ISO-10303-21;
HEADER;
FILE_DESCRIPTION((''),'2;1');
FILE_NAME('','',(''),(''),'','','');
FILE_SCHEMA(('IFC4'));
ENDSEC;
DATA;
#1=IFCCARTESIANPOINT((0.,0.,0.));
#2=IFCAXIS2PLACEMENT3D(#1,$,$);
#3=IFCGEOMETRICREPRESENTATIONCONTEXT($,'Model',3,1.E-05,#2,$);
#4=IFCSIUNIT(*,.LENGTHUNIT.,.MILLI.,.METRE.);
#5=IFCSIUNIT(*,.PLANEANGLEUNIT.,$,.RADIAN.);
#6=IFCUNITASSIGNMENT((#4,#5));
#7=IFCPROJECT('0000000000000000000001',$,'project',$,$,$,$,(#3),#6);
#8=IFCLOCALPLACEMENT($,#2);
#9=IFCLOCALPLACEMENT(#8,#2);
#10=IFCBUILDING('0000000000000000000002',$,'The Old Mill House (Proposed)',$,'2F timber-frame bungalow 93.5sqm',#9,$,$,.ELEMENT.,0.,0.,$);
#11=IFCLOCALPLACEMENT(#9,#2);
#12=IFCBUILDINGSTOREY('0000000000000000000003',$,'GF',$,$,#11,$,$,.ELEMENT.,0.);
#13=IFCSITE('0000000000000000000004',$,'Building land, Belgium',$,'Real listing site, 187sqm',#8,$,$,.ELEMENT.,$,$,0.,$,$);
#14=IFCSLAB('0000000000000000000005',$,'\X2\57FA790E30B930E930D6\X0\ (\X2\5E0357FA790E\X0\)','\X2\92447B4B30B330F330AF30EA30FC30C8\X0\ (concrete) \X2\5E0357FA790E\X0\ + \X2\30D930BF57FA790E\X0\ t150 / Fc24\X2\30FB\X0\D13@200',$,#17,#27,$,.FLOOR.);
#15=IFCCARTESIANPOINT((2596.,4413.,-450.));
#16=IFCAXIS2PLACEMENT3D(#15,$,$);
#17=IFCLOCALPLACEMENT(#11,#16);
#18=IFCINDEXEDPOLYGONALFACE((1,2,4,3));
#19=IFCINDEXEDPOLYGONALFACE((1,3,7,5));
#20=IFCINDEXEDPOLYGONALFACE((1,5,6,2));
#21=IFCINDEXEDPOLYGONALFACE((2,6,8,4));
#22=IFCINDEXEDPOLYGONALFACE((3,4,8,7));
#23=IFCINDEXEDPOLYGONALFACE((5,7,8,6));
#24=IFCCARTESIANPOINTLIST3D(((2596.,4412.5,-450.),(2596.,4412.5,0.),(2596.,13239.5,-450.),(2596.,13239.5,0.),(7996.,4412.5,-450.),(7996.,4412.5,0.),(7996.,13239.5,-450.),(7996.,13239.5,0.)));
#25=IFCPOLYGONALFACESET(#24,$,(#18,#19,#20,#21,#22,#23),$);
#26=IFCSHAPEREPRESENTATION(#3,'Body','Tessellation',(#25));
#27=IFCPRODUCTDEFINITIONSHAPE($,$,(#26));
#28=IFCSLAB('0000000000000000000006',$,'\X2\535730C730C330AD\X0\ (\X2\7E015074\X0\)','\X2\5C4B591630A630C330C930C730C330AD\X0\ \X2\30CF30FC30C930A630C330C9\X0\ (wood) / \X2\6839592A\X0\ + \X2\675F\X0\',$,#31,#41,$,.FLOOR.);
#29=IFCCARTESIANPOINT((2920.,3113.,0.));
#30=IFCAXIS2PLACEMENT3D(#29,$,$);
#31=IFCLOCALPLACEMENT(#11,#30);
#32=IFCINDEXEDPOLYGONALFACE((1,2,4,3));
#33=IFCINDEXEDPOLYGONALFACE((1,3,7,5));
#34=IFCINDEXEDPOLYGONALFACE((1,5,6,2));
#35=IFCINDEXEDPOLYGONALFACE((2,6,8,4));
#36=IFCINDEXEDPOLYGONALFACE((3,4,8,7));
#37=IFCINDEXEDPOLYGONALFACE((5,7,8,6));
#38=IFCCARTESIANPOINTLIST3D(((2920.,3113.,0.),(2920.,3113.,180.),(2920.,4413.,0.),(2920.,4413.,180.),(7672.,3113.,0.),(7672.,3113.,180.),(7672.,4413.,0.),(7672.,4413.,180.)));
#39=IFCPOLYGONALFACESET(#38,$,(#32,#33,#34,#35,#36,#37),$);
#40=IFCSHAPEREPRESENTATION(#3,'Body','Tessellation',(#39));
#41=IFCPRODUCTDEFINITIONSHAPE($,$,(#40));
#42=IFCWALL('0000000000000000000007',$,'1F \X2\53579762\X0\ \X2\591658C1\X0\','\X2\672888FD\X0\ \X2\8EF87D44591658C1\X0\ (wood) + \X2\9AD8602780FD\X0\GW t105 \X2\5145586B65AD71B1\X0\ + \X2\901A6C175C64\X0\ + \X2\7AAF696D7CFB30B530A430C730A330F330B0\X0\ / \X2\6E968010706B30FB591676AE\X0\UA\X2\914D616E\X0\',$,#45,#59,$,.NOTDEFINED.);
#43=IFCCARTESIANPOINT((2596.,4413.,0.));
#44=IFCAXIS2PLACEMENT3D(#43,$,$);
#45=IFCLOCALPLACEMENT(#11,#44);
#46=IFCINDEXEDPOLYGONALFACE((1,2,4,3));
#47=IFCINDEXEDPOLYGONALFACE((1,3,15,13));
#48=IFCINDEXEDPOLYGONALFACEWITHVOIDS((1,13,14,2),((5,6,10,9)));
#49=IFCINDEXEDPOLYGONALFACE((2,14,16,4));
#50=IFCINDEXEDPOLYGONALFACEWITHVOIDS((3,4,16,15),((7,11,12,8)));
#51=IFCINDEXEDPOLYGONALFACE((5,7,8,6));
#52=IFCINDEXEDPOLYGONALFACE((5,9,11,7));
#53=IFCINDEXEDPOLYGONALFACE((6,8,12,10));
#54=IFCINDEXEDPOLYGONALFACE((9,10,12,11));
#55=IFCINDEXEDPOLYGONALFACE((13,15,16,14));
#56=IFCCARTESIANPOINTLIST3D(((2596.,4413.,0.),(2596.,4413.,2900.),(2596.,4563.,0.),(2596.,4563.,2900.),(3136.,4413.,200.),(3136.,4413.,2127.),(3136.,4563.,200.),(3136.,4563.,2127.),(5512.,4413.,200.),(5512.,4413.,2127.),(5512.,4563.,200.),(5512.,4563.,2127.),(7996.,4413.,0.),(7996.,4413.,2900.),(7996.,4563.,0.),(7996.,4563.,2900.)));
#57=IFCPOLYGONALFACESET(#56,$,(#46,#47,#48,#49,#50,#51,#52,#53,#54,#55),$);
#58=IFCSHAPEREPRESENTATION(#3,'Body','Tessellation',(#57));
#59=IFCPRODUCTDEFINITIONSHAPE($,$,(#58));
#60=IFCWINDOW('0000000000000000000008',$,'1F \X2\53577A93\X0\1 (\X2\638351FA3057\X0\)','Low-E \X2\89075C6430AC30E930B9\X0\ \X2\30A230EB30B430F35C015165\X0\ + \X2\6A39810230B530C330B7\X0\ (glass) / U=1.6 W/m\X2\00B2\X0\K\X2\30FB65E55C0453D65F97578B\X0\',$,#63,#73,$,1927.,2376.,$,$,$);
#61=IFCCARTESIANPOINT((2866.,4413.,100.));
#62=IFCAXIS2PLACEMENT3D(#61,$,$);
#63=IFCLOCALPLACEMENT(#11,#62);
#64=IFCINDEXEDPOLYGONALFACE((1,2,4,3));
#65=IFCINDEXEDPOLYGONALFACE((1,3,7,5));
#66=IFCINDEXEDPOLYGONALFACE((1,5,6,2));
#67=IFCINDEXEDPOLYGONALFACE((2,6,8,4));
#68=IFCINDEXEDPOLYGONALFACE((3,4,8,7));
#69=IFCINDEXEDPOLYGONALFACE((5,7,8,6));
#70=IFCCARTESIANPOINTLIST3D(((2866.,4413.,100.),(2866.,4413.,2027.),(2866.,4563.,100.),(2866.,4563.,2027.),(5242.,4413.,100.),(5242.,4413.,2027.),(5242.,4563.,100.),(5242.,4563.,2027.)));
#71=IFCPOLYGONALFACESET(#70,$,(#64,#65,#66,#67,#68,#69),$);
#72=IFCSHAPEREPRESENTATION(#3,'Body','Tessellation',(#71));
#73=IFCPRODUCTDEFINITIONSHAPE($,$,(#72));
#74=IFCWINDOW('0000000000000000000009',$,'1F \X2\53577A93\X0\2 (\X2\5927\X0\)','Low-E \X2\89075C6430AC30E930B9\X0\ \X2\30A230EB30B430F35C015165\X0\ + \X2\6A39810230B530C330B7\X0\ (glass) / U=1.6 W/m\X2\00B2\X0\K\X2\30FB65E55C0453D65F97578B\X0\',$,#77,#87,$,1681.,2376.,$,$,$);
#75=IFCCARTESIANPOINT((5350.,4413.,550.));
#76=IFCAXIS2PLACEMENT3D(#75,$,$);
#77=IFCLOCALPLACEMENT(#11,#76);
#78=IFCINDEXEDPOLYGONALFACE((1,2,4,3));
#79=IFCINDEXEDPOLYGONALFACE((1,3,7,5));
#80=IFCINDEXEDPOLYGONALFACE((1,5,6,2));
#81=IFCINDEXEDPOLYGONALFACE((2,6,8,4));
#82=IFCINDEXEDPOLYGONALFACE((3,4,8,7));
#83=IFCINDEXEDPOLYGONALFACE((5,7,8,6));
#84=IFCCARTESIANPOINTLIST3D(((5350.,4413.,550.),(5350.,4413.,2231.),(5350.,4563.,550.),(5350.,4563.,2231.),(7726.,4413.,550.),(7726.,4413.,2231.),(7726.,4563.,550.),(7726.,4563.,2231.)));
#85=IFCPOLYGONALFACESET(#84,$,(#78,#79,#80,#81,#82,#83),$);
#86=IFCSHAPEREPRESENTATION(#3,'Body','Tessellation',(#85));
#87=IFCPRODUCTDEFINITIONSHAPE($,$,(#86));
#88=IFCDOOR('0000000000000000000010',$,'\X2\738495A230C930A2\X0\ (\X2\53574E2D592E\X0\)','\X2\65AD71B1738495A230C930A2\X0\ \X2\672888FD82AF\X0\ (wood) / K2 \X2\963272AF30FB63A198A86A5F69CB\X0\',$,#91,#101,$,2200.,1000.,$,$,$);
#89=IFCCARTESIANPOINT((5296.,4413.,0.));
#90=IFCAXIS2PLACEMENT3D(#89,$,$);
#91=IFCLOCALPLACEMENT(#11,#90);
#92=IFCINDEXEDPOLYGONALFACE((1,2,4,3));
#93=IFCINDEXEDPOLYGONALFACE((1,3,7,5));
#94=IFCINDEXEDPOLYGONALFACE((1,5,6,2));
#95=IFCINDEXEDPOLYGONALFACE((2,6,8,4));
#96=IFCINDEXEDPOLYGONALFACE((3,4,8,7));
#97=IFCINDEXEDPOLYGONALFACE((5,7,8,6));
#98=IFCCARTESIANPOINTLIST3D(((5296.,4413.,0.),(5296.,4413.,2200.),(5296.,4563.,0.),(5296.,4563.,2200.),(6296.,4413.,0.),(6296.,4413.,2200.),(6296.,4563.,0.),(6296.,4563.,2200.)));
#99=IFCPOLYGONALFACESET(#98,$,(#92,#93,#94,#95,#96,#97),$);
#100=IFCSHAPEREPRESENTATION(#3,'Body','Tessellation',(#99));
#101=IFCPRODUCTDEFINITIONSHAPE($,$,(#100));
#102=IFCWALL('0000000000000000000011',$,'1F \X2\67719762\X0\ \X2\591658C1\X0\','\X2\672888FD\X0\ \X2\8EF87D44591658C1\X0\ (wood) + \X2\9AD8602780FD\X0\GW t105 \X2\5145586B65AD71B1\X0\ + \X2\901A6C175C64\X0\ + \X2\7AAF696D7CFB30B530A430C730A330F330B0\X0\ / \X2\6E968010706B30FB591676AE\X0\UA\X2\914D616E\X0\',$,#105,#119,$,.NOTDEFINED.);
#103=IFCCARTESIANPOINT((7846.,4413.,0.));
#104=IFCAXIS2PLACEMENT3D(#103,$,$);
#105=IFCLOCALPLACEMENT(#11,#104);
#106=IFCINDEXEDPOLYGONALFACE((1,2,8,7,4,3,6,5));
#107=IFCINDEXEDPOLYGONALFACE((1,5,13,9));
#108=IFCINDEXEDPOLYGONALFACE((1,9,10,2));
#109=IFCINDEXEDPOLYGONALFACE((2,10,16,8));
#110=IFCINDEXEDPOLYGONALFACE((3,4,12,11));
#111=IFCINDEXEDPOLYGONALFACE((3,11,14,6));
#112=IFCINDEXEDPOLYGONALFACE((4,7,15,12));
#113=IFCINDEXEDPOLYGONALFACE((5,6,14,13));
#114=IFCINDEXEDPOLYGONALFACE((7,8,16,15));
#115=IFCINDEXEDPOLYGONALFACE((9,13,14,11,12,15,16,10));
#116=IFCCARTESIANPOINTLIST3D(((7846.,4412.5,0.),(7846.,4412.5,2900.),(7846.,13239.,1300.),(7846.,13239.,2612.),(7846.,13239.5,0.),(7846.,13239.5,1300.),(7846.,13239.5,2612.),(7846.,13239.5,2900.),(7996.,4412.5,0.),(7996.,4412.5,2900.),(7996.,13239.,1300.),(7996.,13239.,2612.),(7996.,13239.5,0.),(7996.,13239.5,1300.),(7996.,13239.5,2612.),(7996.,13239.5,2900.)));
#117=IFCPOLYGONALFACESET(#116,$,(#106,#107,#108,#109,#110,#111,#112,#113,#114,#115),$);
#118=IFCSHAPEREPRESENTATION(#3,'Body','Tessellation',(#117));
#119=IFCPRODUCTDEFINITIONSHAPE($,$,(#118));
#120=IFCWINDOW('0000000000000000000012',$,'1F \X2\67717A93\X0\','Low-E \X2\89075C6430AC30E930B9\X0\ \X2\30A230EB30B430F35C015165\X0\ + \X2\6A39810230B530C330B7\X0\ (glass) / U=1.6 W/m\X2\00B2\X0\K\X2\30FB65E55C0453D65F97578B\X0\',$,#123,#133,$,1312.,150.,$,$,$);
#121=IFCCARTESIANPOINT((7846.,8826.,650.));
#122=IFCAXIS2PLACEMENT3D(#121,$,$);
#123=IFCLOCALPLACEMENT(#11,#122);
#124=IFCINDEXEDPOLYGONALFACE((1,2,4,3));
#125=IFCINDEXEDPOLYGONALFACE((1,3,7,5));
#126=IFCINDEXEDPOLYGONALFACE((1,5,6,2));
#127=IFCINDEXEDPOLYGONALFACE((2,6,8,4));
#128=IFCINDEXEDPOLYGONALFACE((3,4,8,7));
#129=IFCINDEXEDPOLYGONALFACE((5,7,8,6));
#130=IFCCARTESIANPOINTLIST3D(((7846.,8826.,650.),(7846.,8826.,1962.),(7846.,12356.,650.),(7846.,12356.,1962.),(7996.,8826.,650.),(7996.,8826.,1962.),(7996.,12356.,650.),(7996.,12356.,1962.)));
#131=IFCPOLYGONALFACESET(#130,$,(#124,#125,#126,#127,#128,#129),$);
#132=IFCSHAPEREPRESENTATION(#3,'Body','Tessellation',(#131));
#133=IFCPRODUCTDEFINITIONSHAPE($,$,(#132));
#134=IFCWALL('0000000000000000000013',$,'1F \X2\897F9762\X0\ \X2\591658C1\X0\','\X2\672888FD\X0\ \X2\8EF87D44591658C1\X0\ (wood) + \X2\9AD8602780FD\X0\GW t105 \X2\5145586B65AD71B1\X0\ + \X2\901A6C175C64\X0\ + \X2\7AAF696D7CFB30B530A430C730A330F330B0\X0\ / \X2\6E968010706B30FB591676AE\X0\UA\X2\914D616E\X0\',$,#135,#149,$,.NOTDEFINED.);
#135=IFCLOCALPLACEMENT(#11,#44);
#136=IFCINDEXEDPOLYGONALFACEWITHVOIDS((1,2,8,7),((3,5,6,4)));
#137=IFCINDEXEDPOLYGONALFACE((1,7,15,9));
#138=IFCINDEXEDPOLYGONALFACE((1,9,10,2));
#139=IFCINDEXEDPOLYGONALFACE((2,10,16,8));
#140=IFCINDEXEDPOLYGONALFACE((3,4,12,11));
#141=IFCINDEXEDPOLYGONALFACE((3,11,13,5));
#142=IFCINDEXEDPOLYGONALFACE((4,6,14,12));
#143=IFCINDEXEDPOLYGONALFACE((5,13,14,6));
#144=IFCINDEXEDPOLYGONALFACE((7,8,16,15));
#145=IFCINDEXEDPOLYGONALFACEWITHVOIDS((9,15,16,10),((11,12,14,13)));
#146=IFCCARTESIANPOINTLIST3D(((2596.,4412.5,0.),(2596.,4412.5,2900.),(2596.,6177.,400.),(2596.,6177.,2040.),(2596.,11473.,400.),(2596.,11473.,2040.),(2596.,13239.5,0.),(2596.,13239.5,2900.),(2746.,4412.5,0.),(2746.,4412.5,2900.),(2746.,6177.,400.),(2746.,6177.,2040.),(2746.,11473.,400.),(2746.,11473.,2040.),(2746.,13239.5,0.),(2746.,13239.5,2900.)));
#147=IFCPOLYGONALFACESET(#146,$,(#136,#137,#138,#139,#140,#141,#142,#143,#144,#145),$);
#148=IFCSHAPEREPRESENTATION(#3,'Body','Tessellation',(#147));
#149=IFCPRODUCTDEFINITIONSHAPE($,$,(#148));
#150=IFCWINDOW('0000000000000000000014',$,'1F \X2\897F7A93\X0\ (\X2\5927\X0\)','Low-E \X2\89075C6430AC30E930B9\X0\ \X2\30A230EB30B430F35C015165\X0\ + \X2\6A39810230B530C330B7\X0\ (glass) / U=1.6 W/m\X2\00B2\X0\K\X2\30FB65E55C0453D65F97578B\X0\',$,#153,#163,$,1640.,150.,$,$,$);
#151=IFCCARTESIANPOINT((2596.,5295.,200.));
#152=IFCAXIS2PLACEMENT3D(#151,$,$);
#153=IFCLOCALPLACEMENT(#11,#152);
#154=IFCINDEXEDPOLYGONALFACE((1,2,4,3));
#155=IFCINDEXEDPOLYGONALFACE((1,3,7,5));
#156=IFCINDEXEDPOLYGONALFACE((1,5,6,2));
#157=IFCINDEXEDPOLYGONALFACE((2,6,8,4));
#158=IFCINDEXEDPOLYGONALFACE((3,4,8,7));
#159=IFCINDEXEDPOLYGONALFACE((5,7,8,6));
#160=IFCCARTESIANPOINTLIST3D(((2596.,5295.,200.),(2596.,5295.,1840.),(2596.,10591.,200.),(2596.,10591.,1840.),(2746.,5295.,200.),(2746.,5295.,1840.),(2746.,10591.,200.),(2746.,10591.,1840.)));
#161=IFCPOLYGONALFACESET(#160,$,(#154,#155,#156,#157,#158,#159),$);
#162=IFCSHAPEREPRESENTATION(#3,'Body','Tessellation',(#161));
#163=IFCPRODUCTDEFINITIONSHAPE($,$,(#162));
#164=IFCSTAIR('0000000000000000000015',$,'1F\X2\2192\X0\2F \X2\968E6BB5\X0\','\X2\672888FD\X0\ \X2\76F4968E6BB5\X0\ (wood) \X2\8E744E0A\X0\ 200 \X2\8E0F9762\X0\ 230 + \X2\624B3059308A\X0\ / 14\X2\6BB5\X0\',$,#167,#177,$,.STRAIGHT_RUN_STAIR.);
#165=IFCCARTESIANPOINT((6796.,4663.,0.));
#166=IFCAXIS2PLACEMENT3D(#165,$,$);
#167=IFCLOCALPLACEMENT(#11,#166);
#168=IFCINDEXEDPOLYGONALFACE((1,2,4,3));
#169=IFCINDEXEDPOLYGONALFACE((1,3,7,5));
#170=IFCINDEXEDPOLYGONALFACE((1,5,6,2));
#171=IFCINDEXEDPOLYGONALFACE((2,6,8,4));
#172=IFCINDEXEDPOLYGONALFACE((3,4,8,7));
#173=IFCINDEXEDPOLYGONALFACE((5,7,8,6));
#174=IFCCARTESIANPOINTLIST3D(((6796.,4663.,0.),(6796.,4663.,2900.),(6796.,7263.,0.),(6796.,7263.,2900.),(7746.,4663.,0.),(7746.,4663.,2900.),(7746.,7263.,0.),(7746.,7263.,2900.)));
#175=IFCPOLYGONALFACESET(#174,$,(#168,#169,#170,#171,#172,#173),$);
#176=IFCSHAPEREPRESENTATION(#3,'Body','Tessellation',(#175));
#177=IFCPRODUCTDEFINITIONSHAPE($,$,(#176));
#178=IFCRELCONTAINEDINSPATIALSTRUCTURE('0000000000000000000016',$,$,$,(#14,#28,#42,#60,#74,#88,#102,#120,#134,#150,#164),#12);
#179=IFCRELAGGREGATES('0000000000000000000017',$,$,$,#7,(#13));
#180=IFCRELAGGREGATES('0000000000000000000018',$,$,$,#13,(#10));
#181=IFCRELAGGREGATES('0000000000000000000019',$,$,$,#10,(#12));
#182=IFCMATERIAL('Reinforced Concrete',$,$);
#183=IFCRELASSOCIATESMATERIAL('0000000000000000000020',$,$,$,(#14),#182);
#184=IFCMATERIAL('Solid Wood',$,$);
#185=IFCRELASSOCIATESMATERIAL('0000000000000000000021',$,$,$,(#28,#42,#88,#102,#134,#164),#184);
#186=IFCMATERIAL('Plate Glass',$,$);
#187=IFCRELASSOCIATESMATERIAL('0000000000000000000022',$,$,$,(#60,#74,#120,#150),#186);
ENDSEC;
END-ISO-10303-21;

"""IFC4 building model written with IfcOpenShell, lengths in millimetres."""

from ifc_helpers import new_model, si_unit, frame, frame_2d, origin, place, context, project, spatial, rectangle, extrude, material, element, fill, save


model = new_model("IFC4")

# Units and contexts
model_context = context("Model", 3, precision=1e-05, world=origin())
ifc_project = project(units=[si_unit("LENGTHUNIT", "METRE", prefix="MILLI"), si_unit("PLANEANGLEUNIT", "RADIAN")], contexts=[model_context])

# Site, building, storey
site_placement = place(None, origin())
site = spatial("IfcSite", under=ifc_project, at=site_placement, Name="Building land, Belgium", ObjectType="Real listing site, 187sqm", CompositionType="ELEMENT", RefElevation=0.0)
building_placement = place(site_placement, origin())
building = spatial("IfcBuilding", under=site, at=building_placement, Name="The Old Mill House (Proposed)", ObjectType="2F timber-frame bungalow 93.5sqm", CompositionType="ELEMENT", ElevationOfRefHeight=0.0, ElevationOfTerrain=0.0)
storey_placement = place(building_placement, origin())
storey = spatial("IfcBuildingStorey", under=building, at=storey_placement, Name="GF", CompositionType="ELEMENT", Elevation=0.0)

# Slabs
ifc_material_1 = material(Name="Reinforced Concrete")
slab_1_placement = place(storey_placement, frame((2596.0, 4413.0, -450.0)))
element("IfcSlab", 1, at=slab_1_placement, inside=storey, material=ifc_material_1, Name="基礎スラブ (布基礎)", Description="鉄筋コンクリート (concrete) 布基礎 + ベタ基礎 t150 / Fc24・D13@200", PredefinedType="FLOOR", context=model_context, shape_type="SweptSolid", body=[
    extrude(rectangle(XDim=5400.0, YDim=8827.0, at=frame_2d((2700.0, 4413.0))), frame((2596.0, 4413.0, -450.0)), (0.0, 0.0, 1.0), 450.0),
])
ifc_material_2 = material(Name="Solid Wood")
slab_2_placement = place(storey_placement, frame((2920.0, 3113.0, 0.0)))
element("IfcSlab", 2, at=slab_2_placement, inside=storey, material=ifc_material_2, Name="南デッキ (縁側)", Description="屋外ウッドデッキ ハードウッド (wood) / 根太 + 束", PredefinedType="FLOOR", context=model_context, shape_type="SweptSolid", body=[
    extrude(rectangle(XDim=4752.0, YDim=1300.0, at=frame_2d((2376.0, 650.0))), frame((2920.0, 3113.0, 0.0)), (0.0, 0.0, 1.0), 180.0),
])

# Wall, openings, windows, door
wall_1_placement = place(storey_placement, frame((2596.0, 4413.0, 0.0)))
wall_1 = element("IfcWall", 3, at=wall_1_placement, inside=storey, material=ifc_material_2, Name="1F 南面 外壁", Description="木製 軸組外壁 (wood) + 高性能GW t105 充填断熱 + 通気層 + 窯業系サイディング / 準耐火・外皮UA配慮", PredefinedType="NOTDEFINED", context=model_context, shape_type="SweptSolid", body=[
    extrude(rectangle(XDim=5400.0, YDim=150.0, at=frame_2d((2700.0, 75.0))), frame((2596.0, 4413.0, 0.0)), (0.0, 0.0, 1.0), 2900.0),
])
opening_1_placement = place(storey_placement, frame((2866.0, 4413.0, 100.0)))
opening_1 = element("IfcOpeningElement", 4, at=opening_1_placement, cuts=wall_1, PredefinedType="NOTDEFINED", context=model_context, shape_type="SweptSolid", body=[
    extrude(rectangle(XDim=2376.0, YDim=150.0, at=frame_2d((1188.0, 75.0))), frame((2866.0, 4413.0, 100.0)), (0.0, 0.0, 1.0), 1927.0),
])
opening_2_placement = place(storey_placement, frame((5350.0, 4413.0, 550.0)))
opening_2 = element("IfcOpeningElement", 5, at=opening_2_placement, cuts=wall_1, PredefinedType="NOTDEFINED", context=model_context, shape_type="SweptSolid", body=[
    extrude(rectangle(XDim=2376.0, YDim=150.0, at=frame_2d((1188.0, 75.0))), frame((5350.0, 4413.0, 550.0)), (0.0, 0.0, 1.0), 1681.0),
])
opening_3_placement = place(storey_placement, frame((5296.0, 4413.0, 0.0)))
opening_3 = element("IfcOpeningElement", 6, at=opening_3_placement, cuts=wall_1, PredefinedType="NOTDEFINED", context=model_context, shape_type="SweptSolid", body=[
    extrude(rectangle(XDim=1000.0, YDim=150.0, at=frame_2d((500.0, 75.0))), frame((5296.0, 4413.0, 0.0)), (0.0, 0.0, 1.0), 2200.0),
])
ifc_material_3 = material(Name="Plate Glass")
window_1_placement = place(storey_placement, frame((2866.0, 4413.0, 100.0)))
window_1 = element("IfcWindow", 7, at=window_1_placement, inside=storey, material=ifc_material_3, Name="1F 南窓1 (掃出し)", Description="Low-E 複層ガラス アルゴン封入 + 樹脂サッシ (glass) / U=1.6 W/m²K・日射取得型", OverallHeight=1927.0, OverallWidth=2376.0, context=model_context, shape_type="SweptSolid", body=[
    extrude(rectangle(XDim=2376.0, YDim=150.0, at=frame_2d((1188.0, 75.0))), frame((2866.0, 4413.0, 100.0)), (0.0, 0.0, 1.0), 1927.0),
])
fill(opening_1, window_1)
window_2_placement = place(storey_placement, frame((5350.0, 4413.0, 550.0)))
window_2 = element("IfcWindow", 8, at=window_2_placement, inside=storey, material=ifc_material_3, Name="1F 南窓2 (大)", Description="Low-E 複層ガラス アルゴン封入 + 樹脂サッシ (glass) / U=1.6 W/m²K・日射取得型", OverallHeight=1681.0, OverallWidth=2376.0, context=model_context, shape_type="SweptSolid", body=[
    extrude(rectangle(XDim=2376.0, YDim=150.0, at=frame_2d((1188.0, 75.0))), frame((5350.0, 4413.0, 550.0)), (0.0, 0.0, 1.0), 1681.0),
])
fill(opening_2, window_2)
door_placement = place(storey_placement, frame((5296.0, 4413.0, 0.0)))
door = element("IfcDoor", 9, at=door_placement, inside=storey, material=ifc_material_2, Name="玄関ドア (南中央)", Description="断熱玄関ドア 木製芯 (wood) / K2 防犯・採風機構", OverallHeight=2200.0, OverallWidth=1000.0, context=model_context, shape_type="SweptSolid", body=[
    extrude(rectangle(XDim=1000.0, YDim=150.0, at=frame_2d((500.0, 75.0))), frame((5296.0, 4413.0, 0.0)), (0.0, 0.0, 1.0), 2200.0),
])
fill(opening_3, door)

# Walls, openings, windows
wall_2_placement = place(storey_placement, frame((7846.0, 4413.0, 0.0)))
wall_2 = element("IfcWall", 10, at=wall_2_placement, inside=storey, material=ifc_material_2, Name="1F 東面 外壁", Description="木製 軸組外壁 (wood) + 高性能GW t105 充填断熱 + 通気層 + 窯業系サイディング / 準耐火・外皮UA配慮", PredefinedType="NOTDEFINED", context=model_context, shape_type="SweptSolid", body=[
    extrude(rectangle(XDim=150.0, YDim=8827.0, at=frame_2d((75.0, 4413.0))), frame((7846.0, 4413.0, 0.0)), (0.0, 0.0, 1.0), 2900.0),
])
opening_4_placement = place(storey_placement, frame((7846.0, 8826.0, 650.0)))
opening_4 = element("IfcOpeningElement", 11, at=opening_4_placement, cuts=wall_2, PredefinedType="NOTDEFINED", context=model_context, shape_type="SweptSolid", body=[
    extrude(rectangle(XDim=150.0, YDim=3530.0, at=frame_2d((75.0, 1765.0))), frame((7846.0, 8826.0, 650.0)), (0.0, 0.0, 1.0), 1312.0),
])
window_3_placement = place(storey_placement, frame((7846.0, 8826.0, 650.0)))
window_3 = element("IfcWindow", 12, at=window_3_placement, inside=storey, material=ifc_material_3, Name="1F 東窓", Description="Low-E 複層ガラス アルゴン封入 + 樹脂サッシ (glass) / U=1.6 W/m²K・日射取得型", OverallHeight=1312.0, OverallWidth=150.0, context=model_context, shape_type="SweptSolid", body=[
    extrude(rectangle(XDim=150.0, YDim=3530.0, at=frame_2d((75.0, 1765.0))), frame((7846.0, 8826.0, 650.0)), (0.0, 0.0, 1.0), 1312.0),
])
fill(opening_4, window_3)
wall_3_placement = place(storey_placement, frame((2596.0, 4413.0, 0.0)))
wall_3 = element("IfcWall", 13, at=wall_3_placement, inside=storey, material=ifc_material_2, Name="1F 西面 外壁", Description="木製 軸組外壁 (wood) + 高性能GW t105 充填断熱 + 通気層 + 窯業系サイディング / 準耐火・外皮UA配慮", PredefinedType="NOTDEFINED", context=model_context, shape_type="SweptSolid", body=[
    extrude(rectangle(XDim=150.0, YDim=8827.0, at=frame_2d((75.0, 4413.0))), frame((2596.0, 4413.0, 0.0)), (0.0, 0.0, 1.0), 2900.0),
])
opening_5_placement = place(storey_placement, frame((2596.0, 5295.0, 200.0)))
opening_5 = element("IfcOpeningElement", 14, at=opening_5_placement, cuts=wall_3, PredefinedType="NOTDEFINED", context=model_context, shape_type="SweptSolid", body=[
    extrude(rectangle(XDim=150.0, YDim=5296.0, at=frame_2d((75.0, 2648.0))), frame((2596.0, 5295.0, 200.0)), (0.0, 0.0, 1.0), 1640.0),
])
window_4_placement = place(storey_placement, frame((2596.0, 5295.0, 200.0)))
window_4 = element("IfcWindow", 15, at=window_4_placement, inside=storey, material=ifc_material_3, Name="1F 西窓 (大)", Description="Low-E 複層ガラス アルゴン封入 + 樹脂サッシ (glass) / U=1.6 W/m²K・日射取得型", OverallHeight=1640.0, OverallWidth=150.0, context=model_context, shape_type="SweptSolid", body=[
    extrude(rectangle(XDim=150.0, YDim=5296.0, at=frame_2d((75.0, 2648.0))), frame((2596.0, 5295.0, 200.0)), (0.0, 0.0, 1.0), 1640.0),
])
fill(opening_5, window_4)

# Stair
stair_placement = place(storey_placement, frame((6796.0, 4663.0, 0.0)))
element("IfcStair", 16, at=stair_placement, inside=storey, material=ifc_material_2, Name="1F→2F 階段", Description="木製 直階段 (wood) 蹴上 200 踏面 230 + 手すり / 14段", PredefinedType="STRAIGHT_RUN_STAIR", context=model_context, shape_type="SweptSolid", body=[
    extrude(rectangle(XDim=950.0, YDim=2600.0, at=frame_2d((475.0, 1300.0))), frame((6796.0, 4663.0, 0.0)), (0.0, 0.0, 1.0), 2900.0),
])

save(model, "model.ifc")
